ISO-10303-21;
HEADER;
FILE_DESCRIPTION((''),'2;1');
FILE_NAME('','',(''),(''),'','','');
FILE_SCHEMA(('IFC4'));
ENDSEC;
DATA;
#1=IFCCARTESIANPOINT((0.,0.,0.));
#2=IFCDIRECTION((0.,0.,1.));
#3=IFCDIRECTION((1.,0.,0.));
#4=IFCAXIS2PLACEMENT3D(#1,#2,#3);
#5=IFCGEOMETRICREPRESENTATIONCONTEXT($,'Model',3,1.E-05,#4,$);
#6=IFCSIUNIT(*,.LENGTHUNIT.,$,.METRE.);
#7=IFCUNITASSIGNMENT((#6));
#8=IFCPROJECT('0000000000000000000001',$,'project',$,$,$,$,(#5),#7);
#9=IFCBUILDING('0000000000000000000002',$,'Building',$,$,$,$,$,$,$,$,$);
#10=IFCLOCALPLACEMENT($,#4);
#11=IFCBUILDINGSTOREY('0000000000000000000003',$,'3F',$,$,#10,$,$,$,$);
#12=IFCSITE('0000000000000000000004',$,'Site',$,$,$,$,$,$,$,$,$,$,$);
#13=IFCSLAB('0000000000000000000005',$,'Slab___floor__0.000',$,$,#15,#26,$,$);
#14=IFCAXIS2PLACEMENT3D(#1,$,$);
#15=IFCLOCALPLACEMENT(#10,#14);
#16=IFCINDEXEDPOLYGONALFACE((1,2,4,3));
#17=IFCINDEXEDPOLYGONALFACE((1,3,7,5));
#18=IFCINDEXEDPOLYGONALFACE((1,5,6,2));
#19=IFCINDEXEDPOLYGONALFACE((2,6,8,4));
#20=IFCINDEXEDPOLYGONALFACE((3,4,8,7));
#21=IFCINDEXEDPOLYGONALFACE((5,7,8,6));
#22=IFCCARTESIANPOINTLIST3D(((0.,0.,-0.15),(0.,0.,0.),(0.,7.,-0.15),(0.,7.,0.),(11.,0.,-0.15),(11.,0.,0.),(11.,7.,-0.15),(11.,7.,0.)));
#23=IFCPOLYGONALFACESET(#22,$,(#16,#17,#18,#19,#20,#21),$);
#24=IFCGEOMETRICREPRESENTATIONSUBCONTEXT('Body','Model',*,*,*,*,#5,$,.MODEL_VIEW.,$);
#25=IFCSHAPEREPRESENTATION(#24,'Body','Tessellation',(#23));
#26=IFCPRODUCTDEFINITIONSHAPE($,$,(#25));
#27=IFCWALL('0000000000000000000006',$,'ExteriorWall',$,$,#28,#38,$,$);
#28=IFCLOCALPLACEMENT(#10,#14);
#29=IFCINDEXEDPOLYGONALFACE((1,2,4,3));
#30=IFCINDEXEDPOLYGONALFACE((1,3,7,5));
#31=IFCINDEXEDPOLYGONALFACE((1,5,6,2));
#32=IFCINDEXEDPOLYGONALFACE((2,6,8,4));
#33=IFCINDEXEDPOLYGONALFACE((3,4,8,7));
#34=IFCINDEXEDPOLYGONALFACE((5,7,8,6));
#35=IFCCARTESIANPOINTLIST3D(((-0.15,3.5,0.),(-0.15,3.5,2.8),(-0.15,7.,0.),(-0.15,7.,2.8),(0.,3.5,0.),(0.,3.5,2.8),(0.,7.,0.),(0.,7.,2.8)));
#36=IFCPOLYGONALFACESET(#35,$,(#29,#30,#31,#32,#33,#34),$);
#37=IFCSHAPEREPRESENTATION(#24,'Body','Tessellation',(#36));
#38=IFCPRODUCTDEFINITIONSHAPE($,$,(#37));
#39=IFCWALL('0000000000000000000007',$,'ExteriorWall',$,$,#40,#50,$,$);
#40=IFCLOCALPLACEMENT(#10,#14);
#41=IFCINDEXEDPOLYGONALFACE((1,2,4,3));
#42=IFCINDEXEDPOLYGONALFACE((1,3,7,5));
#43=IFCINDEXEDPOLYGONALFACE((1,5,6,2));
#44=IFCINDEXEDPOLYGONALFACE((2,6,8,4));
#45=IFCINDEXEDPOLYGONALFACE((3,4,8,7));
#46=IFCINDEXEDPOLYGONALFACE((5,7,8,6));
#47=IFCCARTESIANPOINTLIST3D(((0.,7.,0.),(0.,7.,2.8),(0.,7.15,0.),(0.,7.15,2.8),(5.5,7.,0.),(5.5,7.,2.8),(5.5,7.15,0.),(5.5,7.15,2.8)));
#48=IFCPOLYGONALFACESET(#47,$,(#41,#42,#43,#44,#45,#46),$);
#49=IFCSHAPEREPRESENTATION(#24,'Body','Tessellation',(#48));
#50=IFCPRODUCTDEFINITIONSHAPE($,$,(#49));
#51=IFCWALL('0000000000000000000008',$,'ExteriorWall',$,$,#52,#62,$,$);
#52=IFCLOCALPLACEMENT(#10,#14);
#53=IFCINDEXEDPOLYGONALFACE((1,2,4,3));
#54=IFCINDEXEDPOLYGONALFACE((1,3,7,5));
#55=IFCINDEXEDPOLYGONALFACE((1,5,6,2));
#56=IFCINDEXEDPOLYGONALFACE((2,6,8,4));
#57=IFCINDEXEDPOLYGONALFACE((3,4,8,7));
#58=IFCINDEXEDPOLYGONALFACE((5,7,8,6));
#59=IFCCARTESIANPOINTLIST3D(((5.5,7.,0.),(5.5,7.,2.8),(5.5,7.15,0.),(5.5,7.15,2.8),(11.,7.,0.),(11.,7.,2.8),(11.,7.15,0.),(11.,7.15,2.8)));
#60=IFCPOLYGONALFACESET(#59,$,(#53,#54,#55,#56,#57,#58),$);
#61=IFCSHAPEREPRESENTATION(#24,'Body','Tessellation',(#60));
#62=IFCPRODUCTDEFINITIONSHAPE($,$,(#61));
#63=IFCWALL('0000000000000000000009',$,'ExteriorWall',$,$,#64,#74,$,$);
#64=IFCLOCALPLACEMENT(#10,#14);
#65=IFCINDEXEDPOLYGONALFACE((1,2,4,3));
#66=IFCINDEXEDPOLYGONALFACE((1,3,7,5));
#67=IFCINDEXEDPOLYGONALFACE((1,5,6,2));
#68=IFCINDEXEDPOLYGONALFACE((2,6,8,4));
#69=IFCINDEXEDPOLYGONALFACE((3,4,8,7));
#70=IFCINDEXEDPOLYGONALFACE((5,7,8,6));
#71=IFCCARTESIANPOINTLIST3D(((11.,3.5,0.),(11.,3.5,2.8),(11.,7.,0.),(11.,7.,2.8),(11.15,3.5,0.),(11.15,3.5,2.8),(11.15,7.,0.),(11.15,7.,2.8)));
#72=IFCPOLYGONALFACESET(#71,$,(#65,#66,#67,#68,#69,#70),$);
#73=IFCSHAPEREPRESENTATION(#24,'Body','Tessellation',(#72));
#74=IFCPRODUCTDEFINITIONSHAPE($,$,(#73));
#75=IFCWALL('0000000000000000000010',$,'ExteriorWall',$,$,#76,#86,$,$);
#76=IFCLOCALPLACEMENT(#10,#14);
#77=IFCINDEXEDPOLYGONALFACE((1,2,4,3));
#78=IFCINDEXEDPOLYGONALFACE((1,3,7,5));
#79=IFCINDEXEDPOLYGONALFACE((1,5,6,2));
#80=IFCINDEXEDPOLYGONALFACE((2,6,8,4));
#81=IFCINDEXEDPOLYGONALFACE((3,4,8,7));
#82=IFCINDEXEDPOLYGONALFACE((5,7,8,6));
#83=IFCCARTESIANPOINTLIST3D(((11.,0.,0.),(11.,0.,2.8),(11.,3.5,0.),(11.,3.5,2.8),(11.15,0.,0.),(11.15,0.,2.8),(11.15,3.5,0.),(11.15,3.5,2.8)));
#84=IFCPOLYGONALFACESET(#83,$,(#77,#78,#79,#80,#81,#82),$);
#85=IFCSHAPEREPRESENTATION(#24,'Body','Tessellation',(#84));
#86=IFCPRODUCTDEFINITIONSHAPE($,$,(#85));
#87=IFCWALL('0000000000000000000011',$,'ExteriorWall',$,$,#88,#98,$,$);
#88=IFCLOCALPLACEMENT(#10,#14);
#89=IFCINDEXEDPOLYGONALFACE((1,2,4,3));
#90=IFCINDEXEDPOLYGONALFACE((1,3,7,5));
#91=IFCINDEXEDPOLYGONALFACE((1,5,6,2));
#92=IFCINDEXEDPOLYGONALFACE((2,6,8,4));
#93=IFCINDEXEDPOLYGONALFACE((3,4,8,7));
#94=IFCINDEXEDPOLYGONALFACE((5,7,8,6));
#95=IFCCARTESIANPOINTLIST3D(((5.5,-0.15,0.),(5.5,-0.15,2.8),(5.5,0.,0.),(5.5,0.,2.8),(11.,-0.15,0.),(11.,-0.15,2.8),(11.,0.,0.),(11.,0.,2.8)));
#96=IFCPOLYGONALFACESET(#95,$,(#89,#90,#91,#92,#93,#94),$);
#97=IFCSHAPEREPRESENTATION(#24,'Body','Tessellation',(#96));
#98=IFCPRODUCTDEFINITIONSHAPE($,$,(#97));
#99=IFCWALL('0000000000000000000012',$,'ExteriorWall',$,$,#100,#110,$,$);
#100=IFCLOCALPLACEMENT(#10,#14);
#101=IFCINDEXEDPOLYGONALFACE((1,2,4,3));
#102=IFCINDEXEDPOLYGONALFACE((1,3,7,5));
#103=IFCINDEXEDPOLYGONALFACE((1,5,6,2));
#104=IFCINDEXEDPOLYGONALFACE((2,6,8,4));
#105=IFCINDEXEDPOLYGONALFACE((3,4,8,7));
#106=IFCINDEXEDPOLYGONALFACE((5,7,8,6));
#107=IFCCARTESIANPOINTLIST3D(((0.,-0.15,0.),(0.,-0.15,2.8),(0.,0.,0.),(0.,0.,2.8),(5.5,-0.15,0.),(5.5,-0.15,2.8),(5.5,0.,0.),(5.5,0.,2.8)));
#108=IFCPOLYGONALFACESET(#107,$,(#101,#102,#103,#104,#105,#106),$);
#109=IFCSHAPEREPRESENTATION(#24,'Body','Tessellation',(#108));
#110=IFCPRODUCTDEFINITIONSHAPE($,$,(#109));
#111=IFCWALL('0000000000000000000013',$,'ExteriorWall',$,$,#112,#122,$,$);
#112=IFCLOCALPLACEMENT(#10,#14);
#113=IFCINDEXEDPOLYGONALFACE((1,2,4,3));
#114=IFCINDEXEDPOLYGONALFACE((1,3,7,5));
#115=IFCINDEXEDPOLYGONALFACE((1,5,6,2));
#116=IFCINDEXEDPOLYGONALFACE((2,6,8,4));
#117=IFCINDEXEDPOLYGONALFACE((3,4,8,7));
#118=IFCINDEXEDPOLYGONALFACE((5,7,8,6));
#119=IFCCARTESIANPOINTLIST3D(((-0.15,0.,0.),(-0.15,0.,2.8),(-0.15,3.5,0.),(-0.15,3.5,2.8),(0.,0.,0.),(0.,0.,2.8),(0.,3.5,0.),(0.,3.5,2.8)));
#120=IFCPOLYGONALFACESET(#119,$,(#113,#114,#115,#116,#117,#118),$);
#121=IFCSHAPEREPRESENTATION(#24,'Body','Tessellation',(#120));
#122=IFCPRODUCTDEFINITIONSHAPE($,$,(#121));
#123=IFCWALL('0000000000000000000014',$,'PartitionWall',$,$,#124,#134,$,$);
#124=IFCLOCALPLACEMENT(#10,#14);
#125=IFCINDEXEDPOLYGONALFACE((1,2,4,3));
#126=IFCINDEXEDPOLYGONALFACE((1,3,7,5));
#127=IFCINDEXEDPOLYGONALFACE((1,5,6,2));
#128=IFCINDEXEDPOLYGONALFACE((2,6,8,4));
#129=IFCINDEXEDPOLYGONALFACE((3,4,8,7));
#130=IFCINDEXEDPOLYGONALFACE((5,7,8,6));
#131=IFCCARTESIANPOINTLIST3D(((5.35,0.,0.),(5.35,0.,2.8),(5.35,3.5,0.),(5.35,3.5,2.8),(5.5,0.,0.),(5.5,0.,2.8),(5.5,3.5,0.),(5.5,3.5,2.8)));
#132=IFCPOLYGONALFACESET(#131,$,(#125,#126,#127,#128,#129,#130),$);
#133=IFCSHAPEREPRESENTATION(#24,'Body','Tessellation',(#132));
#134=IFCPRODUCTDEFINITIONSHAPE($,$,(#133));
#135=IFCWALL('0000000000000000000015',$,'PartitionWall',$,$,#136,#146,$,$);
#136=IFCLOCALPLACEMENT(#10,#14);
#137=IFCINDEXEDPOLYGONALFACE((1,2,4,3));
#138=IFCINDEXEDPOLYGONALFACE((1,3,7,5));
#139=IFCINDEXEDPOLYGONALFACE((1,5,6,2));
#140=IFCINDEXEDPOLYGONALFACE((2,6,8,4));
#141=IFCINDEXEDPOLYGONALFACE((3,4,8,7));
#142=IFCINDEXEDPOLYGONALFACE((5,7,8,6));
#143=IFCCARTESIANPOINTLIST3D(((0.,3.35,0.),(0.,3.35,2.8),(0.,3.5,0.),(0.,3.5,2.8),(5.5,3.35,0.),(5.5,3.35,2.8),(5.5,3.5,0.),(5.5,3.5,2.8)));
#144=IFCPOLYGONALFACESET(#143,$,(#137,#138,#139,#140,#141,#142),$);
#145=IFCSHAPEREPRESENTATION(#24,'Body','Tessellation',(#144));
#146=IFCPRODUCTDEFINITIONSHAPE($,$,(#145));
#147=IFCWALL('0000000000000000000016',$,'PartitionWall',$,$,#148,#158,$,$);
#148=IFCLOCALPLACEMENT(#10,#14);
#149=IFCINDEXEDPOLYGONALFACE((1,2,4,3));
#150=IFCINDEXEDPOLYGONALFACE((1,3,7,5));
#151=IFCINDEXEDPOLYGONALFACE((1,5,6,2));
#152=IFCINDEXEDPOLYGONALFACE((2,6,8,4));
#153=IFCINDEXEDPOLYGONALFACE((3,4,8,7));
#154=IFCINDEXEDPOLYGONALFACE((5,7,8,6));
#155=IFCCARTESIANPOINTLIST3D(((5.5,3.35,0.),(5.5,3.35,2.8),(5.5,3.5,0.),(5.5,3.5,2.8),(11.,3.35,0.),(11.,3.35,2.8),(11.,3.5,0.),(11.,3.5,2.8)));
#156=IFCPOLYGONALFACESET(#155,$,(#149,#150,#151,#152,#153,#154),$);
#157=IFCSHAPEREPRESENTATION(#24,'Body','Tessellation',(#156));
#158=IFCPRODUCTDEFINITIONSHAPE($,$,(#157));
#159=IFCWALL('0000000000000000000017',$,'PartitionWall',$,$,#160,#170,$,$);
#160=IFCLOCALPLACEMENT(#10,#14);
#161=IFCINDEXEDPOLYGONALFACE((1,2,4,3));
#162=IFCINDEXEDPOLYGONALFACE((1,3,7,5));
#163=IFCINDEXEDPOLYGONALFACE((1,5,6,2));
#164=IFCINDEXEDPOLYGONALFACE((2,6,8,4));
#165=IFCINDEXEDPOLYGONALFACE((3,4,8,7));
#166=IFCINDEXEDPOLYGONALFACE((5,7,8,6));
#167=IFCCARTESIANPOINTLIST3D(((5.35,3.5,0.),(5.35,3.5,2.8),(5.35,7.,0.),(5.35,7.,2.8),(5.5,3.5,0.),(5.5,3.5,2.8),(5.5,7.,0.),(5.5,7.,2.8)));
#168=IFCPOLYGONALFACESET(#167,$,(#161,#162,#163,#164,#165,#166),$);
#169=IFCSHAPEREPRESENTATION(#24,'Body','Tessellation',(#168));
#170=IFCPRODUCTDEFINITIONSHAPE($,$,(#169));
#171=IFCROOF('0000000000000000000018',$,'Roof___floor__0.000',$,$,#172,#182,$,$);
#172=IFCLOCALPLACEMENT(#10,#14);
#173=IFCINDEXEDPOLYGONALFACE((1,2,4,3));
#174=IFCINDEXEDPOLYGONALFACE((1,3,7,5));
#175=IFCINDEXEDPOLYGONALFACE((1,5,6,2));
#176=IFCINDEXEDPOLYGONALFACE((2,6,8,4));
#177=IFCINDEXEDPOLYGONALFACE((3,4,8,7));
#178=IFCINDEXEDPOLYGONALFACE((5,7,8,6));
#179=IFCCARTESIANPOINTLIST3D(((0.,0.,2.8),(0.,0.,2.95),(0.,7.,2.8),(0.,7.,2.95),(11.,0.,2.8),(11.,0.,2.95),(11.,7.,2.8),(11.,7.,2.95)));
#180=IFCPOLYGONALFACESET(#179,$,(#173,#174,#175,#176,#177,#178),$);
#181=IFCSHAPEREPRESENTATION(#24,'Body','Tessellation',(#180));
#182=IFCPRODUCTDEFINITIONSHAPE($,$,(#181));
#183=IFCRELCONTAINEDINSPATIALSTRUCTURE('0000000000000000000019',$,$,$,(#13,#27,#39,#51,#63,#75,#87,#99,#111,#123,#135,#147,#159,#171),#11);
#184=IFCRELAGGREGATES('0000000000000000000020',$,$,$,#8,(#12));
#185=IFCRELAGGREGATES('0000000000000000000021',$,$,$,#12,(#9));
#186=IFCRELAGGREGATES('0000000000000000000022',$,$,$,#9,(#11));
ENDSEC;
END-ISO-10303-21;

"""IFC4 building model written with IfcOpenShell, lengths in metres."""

from ifc_helpers import new_model, si_unit, frame, frame_2d, origin_with_axes, place, context, subcontext, project, spatial, rectangle, extrude, element, save


model = new_model("IFC4")

# Units and contexts
model_context = context("Model", 3, precision=1e-05, world=origin_with_axes())
body_context = subcontext(model_context, "Body", "Model", "MODEL_VIEW")
ifc_project = project(units=[si_unit("LENGTHUNIT", "METRE")], contexts=[model_context])

# Site, building, storey
site = spatial("IfcSite", under=ifc_project, Name="Site")
building = spatial("IfcBuilding", under=site, Name="Building")
storey_placement = place(None, origin_with_axes())
storey = spatial("IfcBuildingStorey", under=building, at=storey_placement, Name="3F")

# Slab
slab_placement = place(storey_placement, frame((0.0, 0.0, -0.15), z_axis=(0.0, 0.0, 1.0), x_axis=(1.0, 0.0, 0.0)))
element("IfcSlab", 1, at=slab_placement, inside=storey, Name="Slab___floor__0.000", context=body_context, shape_type="SweptSolid", body=[
    extrude(rectangle(XDim=11.0, YDim=7.0, at=frame_2d((5.5, 3.5), x_axis=(1.0, 0.0))), origin_with_axes(), (0.0, 0.0, 1.0), 0.15),
])

# Walls
wall_1_placement = place(storey_placement, frame((0.0, 3.5, 0.0), z_axis=(0.0, 0.0, 1.0), x_axis=(0.0, 1.0, 0.0)))
element("IfcWall", 2, at=wall_1_placement, inside=storey, Name="ExteriorWall", context=body_context, shape_type="SweptSolid", body=[
    extrude(rectangle(XDim=3.5, YDim=0.15, at=frame_2d((1.75, 0.075), x_axis=(1.0, 0.0))), origin_with_axes(), (0.0, 0.0, 1.0), 2.8),
])
for number, where, z_axis, x_axis, name in (
    (3, (0.0, 7.0, 0.0), (0.0, 0.0, 1.0), (1.0, 0.0, 0.0), "ExteriorWall"),
    (4, (5.5, 7.0, 0.0), (0.0, 0.0, 1.0), (1.0, 0.0, 0.0), "ExteriorWall"),
):
    element("IfcWall", number, at=place(storey_placement, frame(where, z_axis=z_axis, x_axis=x_axis)), inside=storey, Name=name, context=body_context, shape_type="SweptSolid", body=[
        extrude(rectangle(XDim=5.5, YDim=0.15, at=frame_2d((2.75, 0.075), x_axis=(1.0, 0.0))), origin_with_axes(), (0.0, 0.0, 1.0), 2.8),
    ])
for number, where, z_axis, x_axis, name in (
    (5, (11.0, 7.0, 0.0), (0.0, 0.0, 1.0), (0.0, -1.0, 0.0), "ExteriorWall"),
    (6, (11.0, 3.5, 0.0), (0.0, 0.0, 1.0), (0.0, -1.0, 0.0), "ExteriorWall"),
):
    element("IfcWall", number, at=place(storey_placement, frame(where, z_axis=z_axis, x_axis=x_axis)), inside=storey, Name=name, context=body_context, shape_type="SweptSolid", body=[
        extrude(rectangle(XDim=3.5, YDim=0.15, at=frame_2d((1.75, 0.075), x_axis=(1.0, 0.0))), origin_with_axes(), (0.0, 0.0, 1.0), 2.8),
    ])
for number, where, z_axis, x_axis, name in (
    (7, (11.0, 0.0, 0.0), (0.0, 0.0, 1.0), (-1.0, 0.0, 0.0), "ExteriorWall"),
    (8, (5.5, 0.0, 0.0), (0.0, 0.0, 1.0), (-1.0, 0.0, 0.0), "ExteriorWall"),
):
    element("IfcWall", number, at=place(storey_placement, frame(where, z_axis=z_axis, x_axis=x_axis)), inside=storey, Name=name, context=body_context, shape_type="SweptSolid", body=[
        extrude(rectangle(XDim=5.5, YDim=0.15, at=frame_2d((2.75, 0.075), x_axis=(1.0, 0.0))), origin_with_axes(), (0.0, 0.0, 1.0), 2.8),
    ])
for number, where, z_axis, x_axis, name in (
    (9, (0.0, 0.0, 0.0), (0.0, 0.0, 1.0), (0.0, 1.0, 0.0), "ExteriorWall"),
    (10, (5.5, 0.0, 0.0), (0.0, 0.0, 1.0), (0.0, 1.0, 0.0), "PartitionWall"),
):
    element("IfcWall", number, at=place(storey_placement, frame(where, z_axis=z_axis, x_axis=x_axis)), inside=storey, Name=name, context=body_context, shape_type="SweptSolid", body=[
        extrude(rectangle(XDim=3.5, YDim=0.15, at=frame_2d((1.75, 0.075), x_axis=(1.0, 0.0))), origin_with_axes(), (0.0, 0.0, 1.0), 2.8),
    ])
for number, where, z_axis, x_axis, name in (
    (11, (5.5, 3.5, 0.0), (0.0, 0.0, 1.0), (-1.0, 0.0, 0.0), "PartitionWall"),
    (12, (11.0, 3.5, 0.0), (0.0, 0.0, 1.0), (-1.0, 0.0, 0.0), "PartitionWall"),
):
    element("IfcWall", number, at=place(storey_placement, frame(where, z_axis=z_axis, x_axis=x_axis)), inside=storey, Name=name, context=body_context, shape_type="SweptSolid", body=[
        extrude(rectangle(XDim=5.5, YDim=0.15, at=frame_2d((2.75, 0.075), x_axis=(1.0, 0.0))), origin_with_axes(), (0.0, 0.0, 1.0), 2.8),
    ])
wall_2_placement = place(storey_placement, frame((5.5, 3.5, 0.0), z_axis=(0.0, 0.0, 1.0), x_axis=(0.0, 1.0, 0.0)))
element("IfcWall", 13, at=wall_2_placement, inside=storey, Name="PartitionWall", context=body_context, shape_type="SweptSolid", body=[
    extrude(rectangle(XDim=3.5, YDim=0.15, at=frame_2d((1.75, 0.075), x_axis=(1.0, 0.0))), origin_with_axes(), (0.0, 0.0, 1.0), 2.8),
])

# Roof
roof_placement = place(storey_placement, frame((0.0, 0.0, 2.8), z_axis=(0.0, 0.0, 1.0), x_axis=(1.0, 0.0, 0.0)))
element("IfcRoof", 14, at=roof_placement, inside=storey, Name="Roof___floor__0.000", context=body_context, shape_type="SweptSolid", body=[
    extrude(rectangle(XDim=11.0, YDim=7.0, at=frame_2d((5.5, 3.5), x_axis=(1.0, 0.0))), origin_with_axes(), (0.0, 0.0, 1.0), 0.15),
])

save(model, "model.ifc")
